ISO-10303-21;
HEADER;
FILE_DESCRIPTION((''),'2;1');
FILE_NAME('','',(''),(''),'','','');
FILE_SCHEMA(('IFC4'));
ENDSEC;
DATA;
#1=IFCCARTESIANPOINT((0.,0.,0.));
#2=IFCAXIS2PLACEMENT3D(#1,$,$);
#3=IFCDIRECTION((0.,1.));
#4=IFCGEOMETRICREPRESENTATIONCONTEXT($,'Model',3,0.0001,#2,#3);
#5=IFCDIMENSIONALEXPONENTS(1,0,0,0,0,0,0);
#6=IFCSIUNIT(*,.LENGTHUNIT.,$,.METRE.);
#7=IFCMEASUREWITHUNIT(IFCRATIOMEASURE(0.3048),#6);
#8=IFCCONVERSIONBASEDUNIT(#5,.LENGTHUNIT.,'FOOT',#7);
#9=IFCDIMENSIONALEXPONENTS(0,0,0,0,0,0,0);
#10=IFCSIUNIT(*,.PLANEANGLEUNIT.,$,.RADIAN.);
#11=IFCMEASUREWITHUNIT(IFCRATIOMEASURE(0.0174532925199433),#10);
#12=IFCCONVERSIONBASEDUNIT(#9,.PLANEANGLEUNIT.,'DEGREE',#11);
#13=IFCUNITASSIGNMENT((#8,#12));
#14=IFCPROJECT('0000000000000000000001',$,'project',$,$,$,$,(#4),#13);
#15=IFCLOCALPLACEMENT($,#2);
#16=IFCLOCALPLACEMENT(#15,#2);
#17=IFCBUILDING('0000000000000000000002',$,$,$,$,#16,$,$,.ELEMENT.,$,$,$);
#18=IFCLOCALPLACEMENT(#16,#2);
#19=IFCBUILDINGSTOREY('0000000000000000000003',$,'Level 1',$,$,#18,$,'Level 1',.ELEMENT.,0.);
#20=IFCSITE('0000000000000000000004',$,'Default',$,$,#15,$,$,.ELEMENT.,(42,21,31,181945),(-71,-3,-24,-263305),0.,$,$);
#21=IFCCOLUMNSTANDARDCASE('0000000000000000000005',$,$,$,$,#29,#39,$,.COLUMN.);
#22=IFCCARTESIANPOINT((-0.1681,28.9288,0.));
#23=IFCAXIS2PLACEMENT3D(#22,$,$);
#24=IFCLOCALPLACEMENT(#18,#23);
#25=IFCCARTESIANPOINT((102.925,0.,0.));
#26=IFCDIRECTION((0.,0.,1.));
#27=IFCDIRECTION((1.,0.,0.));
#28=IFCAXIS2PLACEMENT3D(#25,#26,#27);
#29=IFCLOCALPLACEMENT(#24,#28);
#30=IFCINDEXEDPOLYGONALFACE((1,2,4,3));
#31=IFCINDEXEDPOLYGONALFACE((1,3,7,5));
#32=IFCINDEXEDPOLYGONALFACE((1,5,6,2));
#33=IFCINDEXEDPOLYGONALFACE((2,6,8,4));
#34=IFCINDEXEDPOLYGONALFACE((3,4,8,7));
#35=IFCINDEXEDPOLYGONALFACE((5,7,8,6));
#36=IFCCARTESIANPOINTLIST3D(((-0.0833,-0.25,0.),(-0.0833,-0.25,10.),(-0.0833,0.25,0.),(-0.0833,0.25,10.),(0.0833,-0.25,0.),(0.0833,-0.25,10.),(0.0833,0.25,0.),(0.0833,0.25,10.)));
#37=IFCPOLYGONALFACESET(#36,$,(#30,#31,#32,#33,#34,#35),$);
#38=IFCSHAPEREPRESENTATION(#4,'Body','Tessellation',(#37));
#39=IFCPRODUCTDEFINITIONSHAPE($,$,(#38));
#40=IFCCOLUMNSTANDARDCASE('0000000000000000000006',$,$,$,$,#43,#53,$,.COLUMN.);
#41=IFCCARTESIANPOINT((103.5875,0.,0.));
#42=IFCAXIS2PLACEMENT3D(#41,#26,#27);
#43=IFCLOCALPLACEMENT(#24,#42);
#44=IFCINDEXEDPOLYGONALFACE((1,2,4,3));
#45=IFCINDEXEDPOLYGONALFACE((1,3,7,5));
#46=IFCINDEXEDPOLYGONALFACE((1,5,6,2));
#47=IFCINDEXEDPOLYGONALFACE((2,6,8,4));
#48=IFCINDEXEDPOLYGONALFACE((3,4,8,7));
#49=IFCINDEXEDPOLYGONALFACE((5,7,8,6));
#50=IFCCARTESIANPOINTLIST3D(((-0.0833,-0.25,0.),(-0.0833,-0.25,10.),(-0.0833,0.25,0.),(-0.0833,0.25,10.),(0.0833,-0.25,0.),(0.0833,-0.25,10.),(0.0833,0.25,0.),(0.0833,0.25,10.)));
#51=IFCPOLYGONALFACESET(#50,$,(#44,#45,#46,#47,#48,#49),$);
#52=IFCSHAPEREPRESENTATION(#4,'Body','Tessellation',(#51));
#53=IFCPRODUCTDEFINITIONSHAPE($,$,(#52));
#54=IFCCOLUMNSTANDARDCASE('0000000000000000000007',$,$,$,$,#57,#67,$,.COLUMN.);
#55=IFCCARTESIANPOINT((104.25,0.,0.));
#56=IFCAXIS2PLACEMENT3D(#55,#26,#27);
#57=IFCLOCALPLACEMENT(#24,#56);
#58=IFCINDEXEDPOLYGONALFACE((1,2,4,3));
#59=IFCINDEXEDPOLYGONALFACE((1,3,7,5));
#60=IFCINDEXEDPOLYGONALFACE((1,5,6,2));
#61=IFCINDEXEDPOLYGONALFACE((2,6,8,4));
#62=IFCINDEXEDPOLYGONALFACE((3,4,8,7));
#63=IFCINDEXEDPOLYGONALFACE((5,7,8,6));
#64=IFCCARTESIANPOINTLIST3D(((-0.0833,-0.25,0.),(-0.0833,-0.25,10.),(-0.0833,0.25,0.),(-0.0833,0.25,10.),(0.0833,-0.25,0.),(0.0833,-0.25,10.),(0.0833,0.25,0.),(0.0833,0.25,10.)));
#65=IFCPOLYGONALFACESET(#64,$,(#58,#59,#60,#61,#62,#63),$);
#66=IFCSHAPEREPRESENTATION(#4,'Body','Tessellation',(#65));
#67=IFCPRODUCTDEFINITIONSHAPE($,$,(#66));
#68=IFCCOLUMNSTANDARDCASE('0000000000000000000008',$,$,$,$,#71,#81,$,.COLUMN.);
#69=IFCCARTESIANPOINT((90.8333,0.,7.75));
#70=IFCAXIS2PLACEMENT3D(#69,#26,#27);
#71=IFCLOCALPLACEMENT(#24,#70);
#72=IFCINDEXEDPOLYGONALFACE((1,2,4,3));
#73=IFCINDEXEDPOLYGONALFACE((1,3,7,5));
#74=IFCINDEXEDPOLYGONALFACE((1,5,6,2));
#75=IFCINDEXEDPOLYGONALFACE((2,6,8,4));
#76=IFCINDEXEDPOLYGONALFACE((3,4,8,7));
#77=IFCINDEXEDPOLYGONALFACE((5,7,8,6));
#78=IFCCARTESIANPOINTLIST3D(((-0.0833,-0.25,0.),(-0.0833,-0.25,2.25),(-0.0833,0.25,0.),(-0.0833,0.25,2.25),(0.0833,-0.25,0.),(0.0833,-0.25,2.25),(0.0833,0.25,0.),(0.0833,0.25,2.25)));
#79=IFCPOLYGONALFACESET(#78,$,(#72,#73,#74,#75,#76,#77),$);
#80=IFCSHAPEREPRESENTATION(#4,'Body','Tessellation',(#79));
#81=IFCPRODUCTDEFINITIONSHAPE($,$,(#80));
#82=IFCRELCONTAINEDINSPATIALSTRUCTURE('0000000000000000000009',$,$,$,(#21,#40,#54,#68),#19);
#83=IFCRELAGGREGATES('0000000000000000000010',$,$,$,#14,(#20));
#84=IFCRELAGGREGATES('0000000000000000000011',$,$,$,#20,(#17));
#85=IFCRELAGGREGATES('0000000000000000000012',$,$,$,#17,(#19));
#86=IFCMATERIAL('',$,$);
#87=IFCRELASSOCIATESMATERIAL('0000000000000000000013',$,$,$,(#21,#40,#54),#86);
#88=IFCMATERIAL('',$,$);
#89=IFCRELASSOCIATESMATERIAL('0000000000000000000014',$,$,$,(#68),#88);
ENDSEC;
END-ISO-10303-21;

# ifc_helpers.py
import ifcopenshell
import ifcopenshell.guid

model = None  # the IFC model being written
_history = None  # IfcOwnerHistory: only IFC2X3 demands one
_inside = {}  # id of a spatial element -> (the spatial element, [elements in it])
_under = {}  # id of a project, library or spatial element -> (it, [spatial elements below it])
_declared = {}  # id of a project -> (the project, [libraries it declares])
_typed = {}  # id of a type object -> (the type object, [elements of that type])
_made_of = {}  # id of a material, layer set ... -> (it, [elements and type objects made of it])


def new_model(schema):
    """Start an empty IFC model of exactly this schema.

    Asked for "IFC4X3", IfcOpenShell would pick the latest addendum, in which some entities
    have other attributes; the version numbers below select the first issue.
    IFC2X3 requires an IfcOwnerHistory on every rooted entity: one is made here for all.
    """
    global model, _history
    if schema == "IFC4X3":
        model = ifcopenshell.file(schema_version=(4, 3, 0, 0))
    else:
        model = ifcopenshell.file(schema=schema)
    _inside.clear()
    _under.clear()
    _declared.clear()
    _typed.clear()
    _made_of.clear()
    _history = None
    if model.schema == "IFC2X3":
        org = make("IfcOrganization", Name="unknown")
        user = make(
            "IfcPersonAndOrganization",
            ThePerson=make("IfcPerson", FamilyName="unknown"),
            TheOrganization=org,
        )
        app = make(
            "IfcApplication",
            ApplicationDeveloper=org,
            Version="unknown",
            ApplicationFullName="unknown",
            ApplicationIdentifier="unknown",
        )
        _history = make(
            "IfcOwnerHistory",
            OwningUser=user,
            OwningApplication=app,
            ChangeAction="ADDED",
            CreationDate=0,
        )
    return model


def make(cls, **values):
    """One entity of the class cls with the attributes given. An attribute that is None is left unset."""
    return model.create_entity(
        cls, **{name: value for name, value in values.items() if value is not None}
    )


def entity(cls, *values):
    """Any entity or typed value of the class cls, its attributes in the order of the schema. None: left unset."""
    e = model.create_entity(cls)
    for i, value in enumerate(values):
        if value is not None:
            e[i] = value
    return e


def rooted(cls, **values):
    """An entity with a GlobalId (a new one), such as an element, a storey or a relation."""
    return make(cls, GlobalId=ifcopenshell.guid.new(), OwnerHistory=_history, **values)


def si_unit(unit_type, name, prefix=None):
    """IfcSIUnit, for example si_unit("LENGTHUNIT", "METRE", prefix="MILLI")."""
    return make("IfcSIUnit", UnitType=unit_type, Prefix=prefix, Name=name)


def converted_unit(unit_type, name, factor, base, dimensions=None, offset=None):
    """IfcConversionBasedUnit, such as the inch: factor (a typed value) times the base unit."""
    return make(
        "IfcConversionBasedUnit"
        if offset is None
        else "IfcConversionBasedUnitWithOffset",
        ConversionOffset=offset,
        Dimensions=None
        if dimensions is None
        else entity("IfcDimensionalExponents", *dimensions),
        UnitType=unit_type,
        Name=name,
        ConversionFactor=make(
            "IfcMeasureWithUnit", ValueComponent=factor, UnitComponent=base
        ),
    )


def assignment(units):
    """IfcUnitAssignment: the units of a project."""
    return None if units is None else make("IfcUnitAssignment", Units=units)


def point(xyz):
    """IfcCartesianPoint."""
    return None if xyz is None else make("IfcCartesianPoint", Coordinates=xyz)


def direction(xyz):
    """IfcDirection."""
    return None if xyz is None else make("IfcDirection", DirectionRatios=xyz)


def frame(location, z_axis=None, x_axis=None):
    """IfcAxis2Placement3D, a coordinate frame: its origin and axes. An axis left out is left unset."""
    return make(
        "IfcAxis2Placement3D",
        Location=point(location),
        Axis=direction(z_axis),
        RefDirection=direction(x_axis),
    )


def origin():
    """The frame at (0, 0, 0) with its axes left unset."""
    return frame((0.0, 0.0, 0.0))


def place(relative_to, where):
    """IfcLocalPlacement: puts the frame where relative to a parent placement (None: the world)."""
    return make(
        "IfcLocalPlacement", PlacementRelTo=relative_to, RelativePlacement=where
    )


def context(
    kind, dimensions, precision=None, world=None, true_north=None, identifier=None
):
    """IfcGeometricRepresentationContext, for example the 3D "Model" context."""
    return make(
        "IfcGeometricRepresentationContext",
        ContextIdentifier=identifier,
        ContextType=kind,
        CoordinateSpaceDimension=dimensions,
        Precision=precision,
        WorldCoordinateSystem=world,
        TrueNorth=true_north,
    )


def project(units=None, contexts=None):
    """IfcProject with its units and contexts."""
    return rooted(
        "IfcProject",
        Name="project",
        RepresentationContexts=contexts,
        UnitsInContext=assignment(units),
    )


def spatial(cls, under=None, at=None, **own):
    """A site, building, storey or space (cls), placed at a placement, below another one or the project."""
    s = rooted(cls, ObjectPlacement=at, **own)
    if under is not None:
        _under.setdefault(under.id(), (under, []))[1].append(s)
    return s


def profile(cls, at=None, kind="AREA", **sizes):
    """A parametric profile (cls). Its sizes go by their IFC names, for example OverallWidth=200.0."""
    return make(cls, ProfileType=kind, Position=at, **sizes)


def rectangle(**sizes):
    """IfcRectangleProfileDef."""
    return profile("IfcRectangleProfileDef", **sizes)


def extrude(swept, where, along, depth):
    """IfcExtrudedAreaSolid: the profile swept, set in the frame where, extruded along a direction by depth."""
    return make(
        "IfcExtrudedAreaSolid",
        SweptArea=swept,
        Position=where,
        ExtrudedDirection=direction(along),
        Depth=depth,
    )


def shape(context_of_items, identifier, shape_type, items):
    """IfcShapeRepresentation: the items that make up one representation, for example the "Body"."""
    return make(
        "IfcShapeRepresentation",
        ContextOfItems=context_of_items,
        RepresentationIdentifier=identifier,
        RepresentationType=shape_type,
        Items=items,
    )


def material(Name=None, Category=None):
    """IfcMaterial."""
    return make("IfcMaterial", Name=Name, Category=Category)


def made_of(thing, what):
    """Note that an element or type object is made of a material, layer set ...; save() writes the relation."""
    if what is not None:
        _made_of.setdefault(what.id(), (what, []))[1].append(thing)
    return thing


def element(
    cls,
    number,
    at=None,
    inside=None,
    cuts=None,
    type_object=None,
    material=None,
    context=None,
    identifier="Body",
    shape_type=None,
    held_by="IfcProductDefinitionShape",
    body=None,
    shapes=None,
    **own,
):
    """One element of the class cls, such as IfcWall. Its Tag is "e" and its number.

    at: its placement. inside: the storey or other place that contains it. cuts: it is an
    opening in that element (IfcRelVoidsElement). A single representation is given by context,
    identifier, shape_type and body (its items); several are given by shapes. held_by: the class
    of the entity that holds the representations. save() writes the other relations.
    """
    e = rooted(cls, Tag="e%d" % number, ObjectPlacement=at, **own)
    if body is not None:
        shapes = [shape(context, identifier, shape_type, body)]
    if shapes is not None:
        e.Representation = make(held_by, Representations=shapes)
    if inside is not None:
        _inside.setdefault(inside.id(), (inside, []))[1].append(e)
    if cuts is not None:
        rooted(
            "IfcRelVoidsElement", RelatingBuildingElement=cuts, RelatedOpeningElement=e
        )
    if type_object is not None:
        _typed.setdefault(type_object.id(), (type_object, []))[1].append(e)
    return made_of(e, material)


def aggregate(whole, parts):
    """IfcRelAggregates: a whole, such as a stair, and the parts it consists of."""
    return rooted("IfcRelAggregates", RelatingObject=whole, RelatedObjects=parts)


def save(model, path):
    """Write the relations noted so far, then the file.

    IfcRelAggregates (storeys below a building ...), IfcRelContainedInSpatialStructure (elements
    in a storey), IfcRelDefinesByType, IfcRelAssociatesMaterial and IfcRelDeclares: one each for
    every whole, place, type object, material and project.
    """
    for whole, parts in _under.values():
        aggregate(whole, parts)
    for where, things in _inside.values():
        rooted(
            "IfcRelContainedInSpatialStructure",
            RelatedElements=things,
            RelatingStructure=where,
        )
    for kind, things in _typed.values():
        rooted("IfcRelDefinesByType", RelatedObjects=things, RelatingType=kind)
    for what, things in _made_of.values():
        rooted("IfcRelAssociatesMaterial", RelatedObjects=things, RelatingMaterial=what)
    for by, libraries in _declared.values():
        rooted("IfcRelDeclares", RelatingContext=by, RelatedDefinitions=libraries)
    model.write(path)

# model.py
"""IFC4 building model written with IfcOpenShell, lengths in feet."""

from ifc_helpers import new_model, entity, si_unit, converted_unit, direction, frame, origin, place, context, project, spatial, rectangle, extrude, material, element, save


model = new_model("IFC4")

# Units and contexts
model_context = context("Model", 3, precision=0.0001, world=origin(), true_north=direction((0.0, 1.0)))
ifc_project = project(units=[converted_unit("LENGTHUNIT", "FOOT", entity("IfcRatioMeasure", 0.3048), si_unit("LENGTHUNIT", "METRE"), dimensions=[1, 0, 0, 0, 0, 0, 0]), converted_unit("PLANEANGLEUNIT", "DEGREE", entity("IfcRatioMeasure", 0.0174532925199433), si_unit("PLANEANGLEUNIT", "RADIAN"), dimensions=[0, 0, 0, 0, 0, 0, 0])], contexts=[model_context])

# Site, building, storey
site_placement = place(None, origin())
site = spatial("IfcSite", under=ifc_project, at=site_placement, Name="Default", CompositionType="ELEMENT", RefLatitude=(42, 21, 31, 181945), RefLongitude=(-71, -3, -24, -263305), RefElevation=0.0)
building_placement = place(site_placement, origin())
building = spatial("IfcBuilding", under=site, at=building_placement, CompositionType="ELEMENT")
storey_placement = place(building_placement, origin())
storey = spatial("IfcBuildingStorey", under=building, at=storey_placement, Name="Level 1", LongName="Level 1", CompositionType="ELEMENT", Elevation=0.0)

# Columns
ifc_material_1 = material(Name="")
placement = place(storey_placement, frame((-0.1681, 28.9288, 0.0)))
for number, where, z_axis, x_axis in (
    (1, (102.925, 0.0, 0.0), (0.0, 0.0, 1.0), (1.0, 0.0, 0.0)),
    (2, (103.5875, 0.0, 0.0), (0.0, 0.0, 1.0), (1.0, 0.0, 0.0)),
    (3, (104.25, 0.0, 0.0), (0.0, 0.0, 1.0), (1.0, 0.0, 0.0)),
):
    element("IfcColumnStandardCase", number, at=place(placement, frame(where, z_axis=z_axis, x_axis=x_axis)), inside=storey, material=ifc_material_1, PredefinedType="COLUMN", context=model_context, shape_type="SweptSolid", body=[
        extrude(rectangle(XDim=0.1667, YDim=0.5), origin(), (0.0, 0.0, 1.0), 10.0),
    ])
ifc_material_2 = material(Name="")
for number, where, z_axis, x_axis in (
    (4, (90.8333, 0.0, 7.75), (0.0, 0.0, 1.0), (1.0, 0.0, 0.0)),
):
    element("IfcColumnStandardCase", number, at=place(placement, frame(where, z_axis=z_axis, x_axis=x_axis)), inside=storey, material=ifc_material_2, PredefinedType="COLUMN", context=model_context, shape_type="SweptSolid", body=[
        extrude(rectangle(XDim=0.1667, YDim=0.5), origin(), (0.0, 0.0, 1.0), 2.25),
    ])

save(model, "model.ifc")
